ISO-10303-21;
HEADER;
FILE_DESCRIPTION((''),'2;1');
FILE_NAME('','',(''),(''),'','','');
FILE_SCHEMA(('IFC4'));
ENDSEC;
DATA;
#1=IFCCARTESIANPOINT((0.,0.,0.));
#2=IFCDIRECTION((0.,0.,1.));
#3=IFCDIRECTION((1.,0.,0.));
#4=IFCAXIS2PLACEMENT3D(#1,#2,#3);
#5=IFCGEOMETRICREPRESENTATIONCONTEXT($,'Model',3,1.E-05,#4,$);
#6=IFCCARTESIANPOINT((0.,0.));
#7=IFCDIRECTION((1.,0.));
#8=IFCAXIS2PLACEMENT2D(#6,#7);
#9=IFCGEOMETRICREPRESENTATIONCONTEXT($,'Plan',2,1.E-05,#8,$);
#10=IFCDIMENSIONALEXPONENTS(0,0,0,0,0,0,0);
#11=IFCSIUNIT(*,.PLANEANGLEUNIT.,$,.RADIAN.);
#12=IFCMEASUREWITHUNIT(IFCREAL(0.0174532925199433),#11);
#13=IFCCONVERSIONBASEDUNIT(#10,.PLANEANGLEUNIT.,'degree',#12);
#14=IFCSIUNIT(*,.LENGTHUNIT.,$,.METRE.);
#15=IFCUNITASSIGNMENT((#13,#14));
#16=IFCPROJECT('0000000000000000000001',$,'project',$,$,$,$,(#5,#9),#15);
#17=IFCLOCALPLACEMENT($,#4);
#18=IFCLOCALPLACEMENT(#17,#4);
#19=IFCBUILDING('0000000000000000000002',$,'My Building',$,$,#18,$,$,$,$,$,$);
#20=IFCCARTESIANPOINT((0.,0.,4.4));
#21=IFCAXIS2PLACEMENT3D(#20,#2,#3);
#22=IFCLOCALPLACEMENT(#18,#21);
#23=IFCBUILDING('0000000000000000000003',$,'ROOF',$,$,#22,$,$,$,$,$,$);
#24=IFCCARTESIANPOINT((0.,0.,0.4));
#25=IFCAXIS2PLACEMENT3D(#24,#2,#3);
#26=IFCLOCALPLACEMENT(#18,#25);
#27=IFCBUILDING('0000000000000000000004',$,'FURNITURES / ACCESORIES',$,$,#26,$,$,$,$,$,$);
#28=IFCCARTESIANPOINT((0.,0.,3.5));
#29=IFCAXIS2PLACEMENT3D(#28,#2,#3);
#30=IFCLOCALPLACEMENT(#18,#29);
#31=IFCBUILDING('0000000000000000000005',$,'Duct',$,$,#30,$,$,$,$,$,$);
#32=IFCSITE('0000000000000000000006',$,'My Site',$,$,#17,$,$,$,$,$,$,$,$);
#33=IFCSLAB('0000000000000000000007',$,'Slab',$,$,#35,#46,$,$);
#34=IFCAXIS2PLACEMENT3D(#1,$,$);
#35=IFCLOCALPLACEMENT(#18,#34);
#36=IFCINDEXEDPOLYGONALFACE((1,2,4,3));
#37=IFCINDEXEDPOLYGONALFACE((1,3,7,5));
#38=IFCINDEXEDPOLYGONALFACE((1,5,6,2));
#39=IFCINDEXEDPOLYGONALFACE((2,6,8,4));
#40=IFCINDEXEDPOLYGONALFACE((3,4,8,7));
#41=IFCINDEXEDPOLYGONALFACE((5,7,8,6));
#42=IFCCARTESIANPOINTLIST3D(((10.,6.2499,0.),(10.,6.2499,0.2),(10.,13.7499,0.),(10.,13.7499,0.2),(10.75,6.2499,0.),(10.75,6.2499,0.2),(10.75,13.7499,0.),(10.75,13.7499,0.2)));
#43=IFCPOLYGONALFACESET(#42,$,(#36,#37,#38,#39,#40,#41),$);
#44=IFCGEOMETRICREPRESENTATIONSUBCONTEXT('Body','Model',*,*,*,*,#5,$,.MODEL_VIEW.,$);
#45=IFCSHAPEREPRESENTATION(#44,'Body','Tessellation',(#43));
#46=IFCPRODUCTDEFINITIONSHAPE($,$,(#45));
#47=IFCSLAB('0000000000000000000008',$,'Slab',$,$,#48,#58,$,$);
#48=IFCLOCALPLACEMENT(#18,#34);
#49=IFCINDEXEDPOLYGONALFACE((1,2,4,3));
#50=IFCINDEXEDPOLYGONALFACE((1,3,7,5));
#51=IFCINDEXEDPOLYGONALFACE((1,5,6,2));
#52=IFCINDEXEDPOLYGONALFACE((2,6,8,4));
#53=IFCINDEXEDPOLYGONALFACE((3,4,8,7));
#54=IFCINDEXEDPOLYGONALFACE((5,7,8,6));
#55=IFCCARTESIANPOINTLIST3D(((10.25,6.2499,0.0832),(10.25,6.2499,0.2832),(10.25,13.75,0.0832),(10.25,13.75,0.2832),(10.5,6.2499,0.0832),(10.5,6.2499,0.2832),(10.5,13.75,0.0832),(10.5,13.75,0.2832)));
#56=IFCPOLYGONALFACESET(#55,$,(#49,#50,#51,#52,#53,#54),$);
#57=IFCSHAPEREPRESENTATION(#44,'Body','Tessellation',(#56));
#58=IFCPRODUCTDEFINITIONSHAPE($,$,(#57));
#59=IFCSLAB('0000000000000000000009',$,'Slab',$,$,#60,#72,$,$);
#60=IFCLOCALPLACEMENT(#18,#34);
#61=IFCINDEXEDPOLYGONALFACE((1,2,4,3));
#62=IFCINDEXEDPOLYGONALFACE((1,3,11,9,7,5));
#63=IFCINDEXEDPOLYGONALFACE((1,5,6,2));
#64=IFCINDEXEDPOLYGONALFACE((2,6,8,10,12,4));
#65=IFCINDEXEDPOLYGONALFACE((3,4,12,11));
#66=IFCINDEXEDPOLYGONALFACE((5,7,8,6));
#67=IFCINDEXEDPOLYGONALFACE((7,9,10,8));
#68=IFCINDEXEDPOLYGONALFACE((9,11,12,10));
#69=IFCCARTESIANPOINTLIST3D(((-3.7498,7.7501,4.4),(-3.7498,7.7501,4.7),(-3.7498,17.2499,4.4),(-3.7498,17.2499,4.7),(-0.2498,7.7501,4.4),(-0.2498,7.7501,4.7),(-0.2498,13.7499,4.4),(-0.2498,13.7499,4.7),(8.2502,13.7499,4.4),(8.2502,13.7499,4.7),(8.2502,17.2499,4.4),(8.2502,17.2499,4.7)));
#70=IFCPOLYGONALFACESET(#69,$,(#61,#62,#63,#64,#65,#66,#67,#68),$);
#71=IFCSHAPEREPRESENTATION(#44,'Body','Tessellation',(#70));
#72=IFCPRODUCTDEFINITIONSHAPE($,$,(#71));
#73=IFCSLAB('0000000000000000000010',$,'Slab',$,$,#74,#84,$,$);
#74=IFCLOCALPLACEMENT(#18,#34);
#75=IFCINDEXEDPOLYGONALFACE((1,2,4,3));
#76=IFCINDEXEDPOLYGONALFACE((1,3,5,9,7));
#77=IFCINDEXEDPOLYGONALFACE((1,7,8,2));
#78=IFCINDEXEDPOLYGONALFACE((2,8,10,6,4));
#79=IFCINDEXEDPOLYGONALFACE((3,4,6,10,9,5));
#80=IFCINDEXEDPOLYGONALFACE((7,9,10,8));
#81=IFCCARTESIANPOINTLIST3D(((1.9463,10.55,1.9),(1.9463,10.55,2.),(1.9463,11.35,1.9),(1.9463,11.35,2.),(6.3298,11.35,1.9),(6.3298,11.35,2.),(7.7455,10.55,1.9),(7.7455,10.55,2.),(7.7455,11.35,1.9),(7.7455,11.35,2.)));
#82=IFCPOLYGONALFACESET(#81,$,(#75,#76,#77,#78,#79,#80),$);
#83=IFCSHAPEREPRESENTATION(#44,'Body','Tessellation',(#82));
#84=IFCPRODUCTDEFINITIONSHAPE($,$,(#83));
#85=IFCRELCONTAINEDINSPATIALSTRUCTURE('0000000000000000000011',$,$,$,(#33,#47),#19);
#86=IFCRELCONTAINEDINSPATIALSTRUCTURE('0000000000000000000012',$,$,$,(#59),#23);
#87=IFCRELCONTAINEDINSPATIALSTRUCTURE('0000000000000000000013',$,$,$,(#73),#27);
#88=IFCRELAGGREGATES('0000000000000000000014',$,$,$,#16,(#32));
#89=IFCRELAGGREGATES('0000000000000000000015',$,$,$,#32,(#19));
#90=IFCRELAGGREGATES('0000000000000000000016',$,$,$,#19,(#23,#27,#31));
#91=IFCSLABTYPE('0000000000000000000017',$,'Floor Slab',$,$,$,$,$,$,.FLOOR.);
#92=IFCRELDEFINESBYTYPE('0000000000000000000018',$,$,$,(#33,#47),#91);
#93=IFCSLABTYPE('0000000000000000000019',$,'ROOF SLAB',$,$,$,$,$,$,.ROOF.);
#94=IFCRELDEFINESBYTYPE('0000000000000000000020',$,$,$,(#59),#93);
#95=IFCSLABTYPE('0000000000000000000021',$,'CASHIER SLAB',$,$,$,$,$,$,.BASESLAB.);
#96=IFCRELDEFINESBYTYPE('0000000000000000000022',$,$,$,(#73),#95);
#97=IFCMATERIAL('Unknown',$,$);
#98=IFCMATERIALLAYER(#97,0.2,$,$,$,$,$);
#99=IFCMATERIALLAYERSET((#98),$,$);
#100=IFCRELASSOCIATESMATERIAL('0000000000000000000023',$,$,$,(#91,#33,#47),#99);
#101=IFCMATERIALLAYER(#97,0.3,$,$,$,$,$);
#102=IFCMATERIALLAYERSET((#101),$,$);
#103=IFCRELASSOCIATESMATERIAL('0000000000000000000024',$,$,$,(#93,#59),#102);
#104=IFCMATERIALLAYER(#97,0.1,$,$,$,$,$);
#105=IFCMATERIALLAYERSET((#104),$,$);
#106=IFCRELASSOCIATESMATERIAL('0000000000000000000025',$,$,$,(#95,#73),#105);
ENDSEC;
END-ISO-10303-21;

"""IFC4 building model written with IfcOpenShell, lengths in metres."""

from ifc_helpers import new_model, entity, si_unit, converted_unit, frame, origin_with_axes, origin_2d_with_axis, place, context, subcontext, project, spatial, indexed_curve, outline, extrude, material, layer, layer_set, layer_usage, type_object, element, save


model = new_model("IFC4")

# Units and contexts
model_context = context("Model", 3, precision=1e-05, world=origin_with_axes())
plan_context = context("Plan", 2, precision=1e-05, world=origin_2d_with_axis())
body_context_1 = subcontext(model_context, "Body", "Model", "MODEL_VIEW")
ifc_project = project(units=[converted_unit("PLANEANGLEUNIT", "degree", entity("IfcReal", 0.0174532925199433), si_unit("PLANEANGLEUNIT", "RADIAN"), dimensions=[0, 0, 0, 0, 0, 0, 0]), si_unit("LENGTHUNIT", "METRE")], contexts=[model_context, plan_context])

# Site, building
site_placement = place(None, origin_with_axes())
site = spatial("IfcSite", under=ifc_project, at=site_placement, Name="My Site")
building_1_placement = place(site_placement, origin_with_axes())
building_1 = spatial("IfcBuilding", under=site, at=building_1_placement, Name="My Building")

# Slabs
ifc_material = material(Name="Unknown")
ifc_layer_1 = layer(ifc_material, 0.2)
ifc_layer_set_1 = layer_set([ifc_layer_1])
ifc_layer_usage_1 = layer_usage(ifc_layer_set_1, "AXIS3", "POSITIVE", 0.0)
slab_type_1 = type_object("IfcSlabType", Name="Floor Slab", PredefinedType="FLOOR", material=ifc_layer_set_1)
slab_1_placement = place(building_1_placement, frame((10.0, 13.7499, 0.0), z_axis=(0.0, 0.0, 1.0), x_axis=(1.0, 0.0, 0.0)))
element("IfcSlab", 1, at=slab_1_placement, inside=building_1, type_object=slab_type_1, material=ifc_layer_usage_1, Name="Slab", context=body_context_1, shape_type="SweptSolid", body=[
    extrude(outline(indexed_curve([(0.0, 0.0), (0.75, 0.0), (0.75, -7.5), (0.0, -7.5), (0.0, 0.0)])), None, (0.0, 0.0, 1.0), 0.2),
])
ifc_layer_usage_2 = layer_usage(ifc_layer_set_1, "AXIS3", "POSITIVE", 0.0)
slab_2_placement = place(building_1_placement, frame((10.25, 13.75, 0.0832), z_axis=(0.0, 0.0, 1.0), x_axis=(1.0, 0.0, 0.0)))
element("IfcSlab", 2, at=slab_2_placement, inside=building_1, type_object=slab_type_1, material=ifc_layer_usage_2, Name="Slab", context=body_context_1, shape_type="SweptSolid", body=[
    extrude(outline(indexed_curve([(0.0, 0.0), (0.25, 0.0), (0.25, -7.5001), (0.0, -7.5001), (0.0, 0.0)])), None, (0.0, 0.0, 1.0), 0.2),
])

# Shared definitions
building_2_placement = place(building_1_placement, frame((0.0, 0.0, 4.4), z_axis=(0.0, 0.0, 1.0), x_axis=(1.0, 0.0, 0.0)))
building_2 = spatial("IfcBuilding", under=building_1, at=building_2_placement, Name="ROOF")

# Slab
ifc_layer_2 = layer(ifc_material, 0.3)
ifc_layer_set_2 = layer_set([ifc_layer_2])
ifc_layer_usage_3 = layer_usage(ifc_layer_set_2, "AXIS3", "POSITIVE", -0.3)
slab_type_2 = type_object("IfcSlabType", Name="ROOF SLAB", PredefinedType="ROOF", material=ifc_layer_set_2)
slab_3_placement = place(building_2_placement, frame((8.2502, 13.7499, 0.3), z_axis=(0.0, 0.0, 1.0), x_axis=(1.0, 0.0, 0.0)))
element("IfcSlab", 3, at=slab_3_placement, inside=building_2, type_object=slab_type_2, material=ifc_layer_usage_3, Name="Slab", context=body_context_1, shape_type="SweptSolid", body=[
    extrude(outline(indexed_curve([(0.0, 0.0), (0.0, 3.5), (-12.0, 3.5), (-12.0, -5.9999), (-8.5, -5.9999), (-8.5, 0.0), (0.0, 0.0)])), frame((0.0, 0.0, -0.3), z_axis=(0.0, 0.0, 1.0), x_axis=(1.0, 0.0, 0.0)), (0.0, 0.0, 1.0), 0.3),
])

# Shared definitions
building_3_placement = place(building_1_placement, frame((0.0, 0.0, 0.4), z_axis=(0.0, 0.0, 1.0), x_axis=(1.0, 0.0, 0.0)))
building_3 = spatial("IfcBuilding", under=building_1, at=building_3_placement, Name="FURNITURES / ACCESORIES")

# Slab
ifc_layer_3 = layer(ifc_material, 0.1)
ifc_layer_set_3 = layer_set([ifc_layer_3])
ifc_layer_usage_4 = layer_usage(ifc_layer_set_3, "AXIS3", "POSITIVE", -0.1)
slab_type_3 = type_object("IfcSlabType", Name="CASHIER SLAB", PredefinedType="BASESLAB", material=ifc_layer_set_3)
slab_4_placement = place(building_3_placement, frame((6.3298, 11.35, 1.6), z_axis=(0.0, 0.0, 1.0), x_axis=(1.0, 0.0, 0.0)))
element("IfcSlab", 4, at=slab_4_placement, inside=building_3, type_object=slab_type_3, material=ifc_layer_usage_4, Name="Slab", context=body_context_1, shape_type="SweptSolid", body=[
    extrude(outline(indexed_curve([(0.0, 0.0), (-4.3835, 0.0), (-4.3835, -0.8), (1.4157, -0.8), (1.4157, 0.0), (0.0, 0.0)])), frame((0.0, 0.0, -0.1), z_axis=(0.0, 0.0, 1.0), x_axis=(1.0, 0.0, 0.0)), (0.0, 0.0, 1.0), 0.1),
])

# Shared definitions
building_4_placement = place(building_1_placement, frame((0.0, 0.0, 3.5), z_axis=(0.0, 0.0, 1.0), x_axis=(1.0, 0.0, 0.0)))
building_4 = spatial("IfcBuilding", under=building_1, at=building_4_placement, Name="Duct")

save(model, "model.ifc")
